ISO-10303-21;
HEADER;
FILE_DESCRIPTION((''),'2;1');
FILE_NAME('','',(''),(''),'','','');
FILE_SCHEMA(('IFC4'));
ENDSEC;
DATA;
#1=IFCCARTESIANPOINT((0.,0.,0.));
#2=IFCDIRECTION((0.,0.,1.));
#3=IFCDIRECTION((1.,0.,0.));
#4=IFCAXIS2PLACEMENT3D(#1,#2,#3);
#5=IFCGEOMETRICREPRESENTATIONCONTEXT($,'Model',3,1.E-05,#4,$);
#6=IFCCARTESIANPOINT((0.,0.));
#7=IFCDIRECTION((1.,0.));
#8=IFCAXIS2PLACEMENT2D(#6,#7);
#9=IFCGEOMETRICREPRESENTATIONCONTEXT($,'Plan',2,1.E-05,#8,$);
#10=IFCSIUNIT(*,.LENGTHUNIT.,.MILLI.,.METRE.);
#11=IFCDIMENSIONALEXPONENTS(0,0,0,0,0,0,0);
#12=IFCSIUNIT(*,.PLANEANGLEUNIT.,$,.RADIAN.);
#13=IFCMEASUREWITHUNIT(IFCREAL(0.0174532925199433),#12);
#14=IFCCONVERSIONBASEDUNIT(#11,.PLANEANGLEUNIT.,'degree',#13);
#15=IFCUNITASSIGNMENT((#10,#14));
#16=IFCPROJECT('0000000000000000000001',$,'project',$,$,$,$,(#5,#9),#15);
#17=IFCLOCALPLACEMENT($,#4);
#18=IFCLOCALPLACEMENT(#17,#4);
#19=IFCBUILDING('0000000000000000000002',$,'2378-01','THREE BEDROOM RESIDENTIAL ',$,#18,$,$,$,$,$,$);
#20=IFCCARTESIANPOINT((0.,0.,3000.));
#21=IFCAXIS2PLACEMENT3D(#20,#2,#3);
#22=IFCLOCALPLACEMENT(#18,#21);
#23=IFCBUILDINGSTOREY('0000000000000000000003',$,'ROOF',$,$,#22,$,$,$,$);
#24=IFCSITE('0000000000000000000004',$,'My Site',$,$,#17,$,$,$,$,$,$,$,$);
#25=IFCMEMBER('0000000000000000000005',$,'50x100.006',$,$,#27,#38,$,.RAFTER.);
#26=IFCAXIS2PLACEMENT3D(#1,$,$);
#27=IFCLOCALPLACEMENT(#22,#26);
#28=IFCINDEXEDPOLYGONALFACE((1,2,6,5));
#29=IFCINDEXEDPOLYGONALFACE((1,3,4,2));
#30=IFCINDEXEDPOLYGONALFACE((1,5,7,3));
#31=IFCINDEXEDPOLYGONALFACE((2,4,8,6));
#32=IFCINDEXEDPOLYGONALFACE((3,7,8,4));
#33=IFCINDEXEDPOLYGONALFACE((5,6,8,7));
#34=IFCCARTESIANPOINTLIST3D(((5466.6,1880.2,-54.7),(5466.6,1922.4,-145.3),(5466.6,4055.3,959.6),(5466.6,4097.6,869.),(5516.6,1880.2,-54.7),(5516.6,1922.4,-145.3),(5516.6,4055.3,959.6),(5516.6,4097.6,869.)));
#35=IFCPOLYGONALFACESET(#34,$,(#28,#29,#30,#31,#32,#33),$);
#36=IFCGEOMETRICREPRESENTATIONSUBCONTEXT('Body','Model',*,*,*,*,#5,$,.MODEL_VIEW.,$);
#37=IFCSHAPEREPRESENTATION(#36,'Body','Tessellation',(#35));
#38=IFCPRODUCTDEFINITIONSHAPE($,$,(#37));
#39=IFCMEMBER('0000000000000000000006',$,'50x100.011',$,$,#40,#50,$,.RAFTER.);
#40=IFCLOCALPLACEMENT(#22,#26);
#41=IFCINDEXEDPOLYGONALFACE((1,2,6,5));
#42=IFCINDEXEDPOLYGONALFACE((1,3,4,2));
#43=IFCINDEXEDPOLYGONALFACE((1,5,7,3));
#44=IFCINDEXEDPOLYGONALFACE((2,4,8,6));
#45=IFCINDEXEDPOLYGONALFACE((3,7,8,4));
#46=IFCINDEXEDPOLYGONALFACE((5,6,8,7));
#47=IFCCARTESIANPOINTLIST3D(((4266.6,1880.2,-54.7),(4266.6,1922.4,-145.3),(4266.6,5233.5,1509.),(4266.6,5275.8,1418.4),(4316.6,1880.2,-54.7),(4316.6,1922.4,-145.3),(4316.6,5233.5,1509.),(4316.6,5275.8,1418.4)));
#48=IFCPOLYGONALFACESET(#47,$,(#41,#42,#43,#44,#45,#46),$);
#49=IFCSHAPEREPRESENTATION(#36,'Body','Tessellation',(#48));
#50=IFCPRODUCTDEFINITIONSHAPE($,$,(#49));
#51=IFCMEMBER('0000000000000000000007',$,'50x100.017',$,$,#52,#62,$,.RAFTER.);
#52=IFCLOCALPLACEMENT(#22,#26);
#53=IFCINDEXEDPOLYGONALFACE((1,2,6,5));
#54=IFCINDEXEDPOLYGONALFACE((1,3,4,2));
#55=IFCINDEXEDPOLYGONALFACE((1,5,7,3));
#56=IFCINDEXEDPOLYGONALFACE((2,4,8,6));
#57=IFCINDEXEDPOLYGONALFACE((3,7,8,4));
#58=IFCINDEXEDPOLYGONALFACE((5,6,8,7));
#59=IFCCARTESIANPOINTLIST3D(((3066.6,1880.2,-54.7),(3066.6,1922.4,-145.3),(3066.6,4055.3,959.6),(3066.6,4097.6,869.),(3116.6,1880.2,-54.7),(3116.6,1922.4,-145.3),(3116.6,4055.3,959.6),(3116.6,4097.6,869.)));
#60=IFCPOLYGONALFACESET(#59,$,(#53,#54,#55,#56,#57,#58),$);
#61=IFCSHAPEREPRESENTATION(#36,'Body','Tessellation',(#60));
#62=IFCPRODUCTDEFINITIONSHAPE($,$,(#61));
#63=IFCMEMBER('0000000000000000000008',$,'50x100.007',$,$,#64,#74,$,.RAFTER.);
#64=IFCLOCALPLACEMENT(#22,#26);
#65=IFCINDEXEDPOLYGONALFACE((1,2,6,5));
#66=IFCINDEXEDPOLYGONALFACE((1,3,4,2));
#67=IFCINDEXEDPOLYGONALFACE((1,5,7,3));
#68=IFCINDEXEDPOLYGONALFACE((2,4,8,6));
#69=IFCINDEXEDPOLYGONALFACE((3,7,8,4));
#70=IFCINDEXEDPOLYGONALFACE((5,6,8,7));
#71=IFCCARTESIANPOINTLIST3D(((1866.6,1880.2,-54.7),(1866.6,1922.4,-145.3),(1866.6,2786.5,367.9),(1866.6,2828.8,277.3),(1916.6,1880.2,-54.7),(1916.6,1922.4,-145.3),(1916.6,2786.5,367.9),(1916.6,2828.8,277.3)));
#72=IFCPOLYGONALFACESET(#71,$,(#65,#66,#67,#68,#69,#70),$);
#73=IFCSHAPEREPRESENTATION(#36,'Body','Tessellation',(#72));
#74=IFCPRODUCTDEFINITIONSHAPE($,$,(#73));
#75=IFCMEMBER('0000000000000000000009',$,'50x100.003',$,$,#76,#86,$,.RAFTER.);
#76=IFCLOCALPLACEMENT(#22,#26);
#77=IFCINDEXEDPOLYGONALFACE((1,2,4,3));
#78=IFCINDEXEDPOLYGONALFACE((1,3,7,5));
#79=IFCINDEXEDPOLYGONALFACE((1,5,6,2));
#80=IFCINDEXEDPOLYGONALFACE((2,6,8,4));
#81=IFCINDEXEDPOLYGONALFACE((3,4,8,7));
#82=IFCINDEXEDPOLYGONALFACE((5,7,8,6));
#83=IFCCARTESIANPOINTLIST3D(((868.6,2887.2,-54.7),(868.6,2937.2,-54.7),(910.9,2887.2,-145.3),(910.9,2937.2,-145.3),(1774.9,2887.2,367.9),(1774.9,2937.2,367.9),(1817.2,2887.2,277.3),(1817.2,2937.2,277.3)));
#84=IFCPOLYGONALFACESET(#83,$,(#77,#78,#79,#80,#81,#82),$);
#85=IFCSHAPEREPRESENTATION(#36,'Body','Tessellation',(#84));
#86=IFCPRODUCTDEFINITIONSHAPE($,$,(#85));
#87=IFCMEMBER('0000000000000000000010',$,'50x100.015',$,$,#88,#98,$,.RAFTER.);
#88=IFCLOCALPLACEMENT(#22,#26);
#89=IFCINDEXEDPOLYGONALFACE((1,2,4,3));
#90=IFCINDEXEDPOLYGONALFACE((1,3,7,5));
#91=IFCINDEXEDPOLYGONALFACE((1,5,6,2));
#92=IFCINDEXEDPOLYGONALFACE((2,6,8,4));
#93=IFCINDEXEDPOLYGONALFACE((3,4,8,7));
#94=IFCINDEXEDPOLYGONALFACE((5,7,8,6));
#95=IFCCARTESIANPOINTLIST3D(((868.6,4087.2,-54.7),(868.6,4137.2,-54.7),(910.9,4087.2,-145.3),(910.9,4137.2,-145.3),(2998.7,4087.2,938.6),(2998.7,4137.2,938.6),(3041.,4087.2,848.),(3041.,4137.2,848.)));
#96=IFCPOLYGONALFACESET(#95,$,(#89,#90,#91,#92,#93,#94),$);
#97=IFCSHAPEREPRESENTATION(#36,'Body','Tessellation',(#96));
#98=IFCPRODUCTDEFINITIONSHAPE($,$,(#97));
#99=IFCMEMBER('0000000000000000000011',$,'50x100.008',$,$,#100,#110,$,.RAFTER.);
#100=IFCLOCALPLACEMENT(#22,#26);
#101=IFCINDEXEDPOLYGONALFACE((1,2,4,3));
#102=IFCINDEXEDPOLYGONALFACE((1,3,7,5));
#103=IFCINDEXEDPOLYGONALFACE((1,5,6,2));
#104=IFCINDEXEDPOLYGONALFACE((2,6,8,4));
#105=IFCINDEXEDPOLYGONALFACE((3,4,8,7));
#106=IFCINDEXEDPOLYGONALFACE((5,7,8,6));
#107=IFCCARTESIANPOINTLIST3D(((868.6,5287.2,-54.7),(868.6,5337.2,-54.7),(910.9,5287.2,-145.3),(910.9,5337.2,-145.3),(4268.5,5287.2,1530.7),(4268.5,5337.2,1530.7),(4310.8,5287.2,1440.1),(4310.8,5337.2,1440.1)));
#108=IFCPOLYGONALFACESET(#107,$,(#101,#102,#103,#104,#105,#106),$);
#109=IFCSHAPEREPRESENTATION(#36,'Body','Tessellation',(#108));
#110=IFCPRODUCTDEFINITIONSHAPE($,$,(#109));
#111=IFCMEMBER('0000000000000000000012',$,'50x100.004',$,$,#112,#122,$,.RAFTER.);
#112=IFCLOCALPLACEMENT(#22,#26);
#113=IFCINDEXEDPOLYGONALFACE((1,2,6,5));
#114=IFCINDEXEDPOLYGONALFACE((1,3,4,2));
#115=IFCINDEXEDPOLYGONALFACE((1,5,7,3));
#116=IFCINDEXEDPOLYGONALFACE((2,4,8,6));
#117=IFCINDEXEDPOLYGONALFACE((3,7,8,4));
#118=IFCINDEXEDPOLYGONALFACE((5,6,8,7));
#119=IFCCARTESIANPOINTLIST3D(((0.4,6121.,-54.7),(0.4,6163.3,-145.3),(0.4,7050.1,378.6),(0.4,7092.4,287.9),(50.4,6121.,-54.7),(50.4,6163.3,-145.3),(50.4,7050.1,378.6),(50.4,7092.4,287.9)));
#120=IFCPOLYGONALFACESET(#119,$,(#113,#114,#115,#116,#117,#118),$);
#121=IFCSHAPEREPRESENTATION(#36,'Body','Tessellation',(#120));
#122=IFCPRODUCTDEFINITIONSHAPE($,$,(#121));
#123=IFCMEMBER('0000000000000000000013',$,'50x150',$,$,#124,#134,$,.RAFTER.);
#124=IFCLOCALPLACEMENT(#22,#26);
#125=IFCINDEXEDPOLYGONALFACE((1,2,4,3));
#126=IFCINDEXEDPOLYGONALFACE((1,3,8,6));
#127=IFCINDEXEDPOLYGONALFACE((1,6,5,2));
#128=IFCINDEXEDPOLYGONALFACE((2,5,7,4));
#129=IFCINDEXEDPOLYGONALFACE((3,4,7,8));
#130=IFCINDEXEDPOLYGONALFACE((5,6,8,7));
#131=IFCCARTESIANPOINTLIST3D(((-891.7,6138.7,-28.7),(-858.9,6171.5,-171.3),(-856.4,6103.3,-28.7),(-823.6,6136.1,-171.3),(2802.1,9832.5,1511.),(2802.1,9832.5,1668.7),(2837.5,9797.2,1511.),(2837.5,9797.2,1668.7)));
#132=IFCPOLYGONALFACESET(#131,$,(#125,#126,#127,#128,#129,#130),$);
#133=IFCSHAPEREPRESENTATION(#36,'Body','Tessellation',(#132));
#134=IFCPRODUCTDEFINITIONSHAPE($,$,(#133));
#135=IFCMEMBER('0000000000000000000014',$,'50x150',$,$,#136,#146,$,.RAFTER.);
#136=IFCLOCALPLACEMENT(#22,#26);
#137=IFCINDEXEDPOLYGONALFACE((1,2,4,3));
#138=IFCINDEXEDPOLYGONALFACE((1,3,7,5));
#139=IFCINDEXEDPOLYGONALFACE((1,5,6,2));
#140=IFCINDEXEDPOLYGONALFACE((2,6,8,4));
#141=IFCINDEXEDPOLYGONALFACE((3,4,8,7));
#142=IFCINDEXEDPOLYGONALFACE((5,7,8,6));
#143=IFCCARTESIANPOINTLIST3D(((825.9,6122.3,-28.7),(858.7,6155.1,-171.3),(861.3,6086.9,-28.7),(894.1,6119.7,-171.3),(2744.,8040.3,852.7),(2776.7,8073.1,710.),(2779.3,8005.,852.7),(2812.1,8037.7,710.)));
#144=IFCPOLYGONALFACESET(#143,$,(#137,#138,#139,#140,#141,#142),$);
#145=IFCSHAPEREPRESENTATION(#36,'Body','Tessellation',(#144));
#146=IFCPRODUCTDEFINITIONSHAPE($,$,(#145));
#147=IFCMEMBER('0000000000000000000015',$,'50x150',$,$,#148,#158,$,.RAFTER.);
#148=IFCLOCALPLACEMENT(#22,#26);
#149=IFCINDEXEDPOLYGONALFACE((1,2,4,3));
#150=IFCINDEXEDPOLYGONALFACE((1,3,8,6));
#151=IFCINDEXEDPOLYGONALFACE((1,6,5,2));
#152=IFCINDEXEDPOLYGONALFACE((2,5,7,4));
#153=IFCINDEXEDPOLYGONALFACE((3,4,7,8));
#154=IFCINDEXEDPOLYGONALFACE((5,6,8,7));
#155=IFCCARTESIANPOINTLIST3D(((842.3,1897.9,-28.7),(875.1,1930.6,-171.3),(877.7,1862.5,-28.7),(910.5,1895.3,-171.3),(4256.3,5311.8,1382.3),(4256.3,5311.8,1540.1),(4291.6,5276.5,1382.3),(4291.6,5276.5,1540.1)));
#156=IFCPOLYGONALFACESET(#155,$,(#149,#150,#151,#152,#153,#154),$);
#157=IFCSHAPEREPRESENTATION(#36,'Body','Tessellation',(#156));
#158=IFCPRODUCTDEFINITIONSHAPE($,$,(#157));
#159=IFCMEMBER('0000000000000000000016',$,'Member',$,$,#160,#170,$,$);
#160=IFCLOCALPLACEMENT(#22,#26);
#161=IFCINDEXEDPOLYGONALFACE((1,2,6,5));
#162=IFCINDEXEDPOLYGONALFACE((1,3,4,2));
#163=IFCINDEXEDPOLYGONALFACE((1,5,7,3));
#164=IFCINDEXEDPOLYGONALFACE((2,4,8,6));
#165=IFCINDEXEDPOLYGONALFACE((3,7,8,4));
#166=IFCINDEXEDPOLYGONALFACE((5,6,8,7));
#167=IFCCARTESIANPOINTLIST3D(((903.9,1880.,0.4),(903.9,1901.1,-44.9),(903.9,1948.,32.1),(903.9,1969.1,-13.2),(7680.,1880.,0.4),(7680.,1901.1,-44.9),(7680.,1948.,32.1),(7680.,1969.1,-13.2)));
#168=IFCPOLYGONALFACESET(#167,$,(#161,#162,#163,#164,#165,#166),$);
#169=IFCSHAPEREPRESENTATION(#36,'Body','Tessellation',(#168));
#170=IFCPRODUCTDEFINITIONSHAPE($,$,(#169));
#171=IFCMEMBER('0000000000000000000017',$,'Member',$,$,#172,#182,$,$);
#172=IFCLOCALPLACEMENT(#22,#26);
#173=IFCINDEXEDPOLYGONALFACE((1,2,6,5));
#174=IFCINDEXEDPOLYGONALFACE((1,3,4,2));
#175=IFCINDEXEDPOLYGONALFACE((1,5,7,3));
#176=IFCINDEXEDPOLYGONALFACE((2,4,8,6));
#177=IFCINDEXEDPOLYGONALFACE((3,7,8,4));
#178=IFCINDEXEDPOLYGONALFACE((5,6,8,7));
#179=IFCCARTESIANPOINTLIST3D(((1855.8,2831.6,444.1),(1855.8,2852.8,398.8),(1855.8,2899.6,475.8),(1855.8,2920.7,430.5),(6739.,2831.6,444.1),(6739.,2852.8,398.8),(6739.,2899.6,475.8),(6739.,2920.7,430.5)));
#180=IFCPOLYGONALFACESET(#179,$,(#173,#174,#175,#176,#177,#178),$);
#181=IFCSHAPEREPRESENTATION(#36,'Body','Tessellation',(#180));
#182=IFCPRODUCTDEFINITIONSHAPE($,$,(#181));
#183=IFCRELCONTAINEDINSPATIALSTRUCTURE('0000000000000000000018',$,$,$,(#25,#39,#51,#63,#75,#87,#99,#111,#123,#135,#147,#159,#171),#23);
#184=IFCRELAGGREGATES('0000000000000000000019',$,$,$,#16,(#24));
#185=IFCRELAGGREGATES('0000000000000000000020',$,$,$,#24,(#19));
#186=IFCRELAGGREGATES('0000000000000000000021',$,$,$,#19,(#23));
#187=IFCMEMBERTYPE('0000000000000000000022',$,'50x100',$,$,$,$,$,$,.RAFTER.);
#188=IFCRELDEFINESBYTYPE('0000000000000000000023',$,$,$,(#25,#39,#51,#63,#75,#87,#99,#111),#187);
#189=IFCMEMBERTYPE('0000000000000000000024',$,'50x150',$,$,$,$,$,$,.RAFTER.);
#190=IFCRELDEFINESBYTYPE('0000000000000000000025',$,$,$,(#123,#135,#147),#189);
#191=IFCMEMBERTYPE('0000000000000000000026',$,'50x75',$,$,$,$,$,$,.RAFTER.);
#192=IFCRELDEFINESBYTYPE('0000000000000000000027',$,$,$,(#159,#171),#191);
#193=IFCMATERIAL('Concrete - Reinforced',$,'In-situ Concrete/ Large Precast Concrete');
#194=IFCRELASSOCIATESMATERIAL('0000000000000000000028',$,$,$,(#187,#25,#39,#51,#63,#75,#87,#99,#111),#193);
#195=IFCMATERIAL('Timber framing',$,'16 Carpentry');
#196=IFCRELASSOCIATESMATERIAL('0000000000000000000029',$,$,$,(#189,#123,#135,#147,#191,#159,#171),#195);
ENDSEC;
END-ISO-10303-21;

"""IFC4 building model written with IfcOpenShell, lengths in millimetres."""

from ifc_helpers import new_model, entity, si_unit, converted_unit, frame, origin_with_axes, origin_2d_with_axis, place, context, subcontext, project, spatial, rectangle, extrude, clip, halfspace, material, material_profile, profile_set, profile_usage, type_object, element, save


model = new_model("IFC4")

# Units and contexts
model_context = context("Model", 3, precision=1e-05, world=origin_with_axes())
plan_context = context("Plan", 2, precision=1e-05, world=origin_2d_with_axis())
body_context = subcontext(model_context, "Body", "Model", "MODEL_VIEW")
ifc_project = project(units=[si_unit("LENGTHUNIT", "METRE", prefix="MILLI"), converted_unit("PLANEANGLEUNIT", "degree", entity("IfcReal", 0.0174532925199433), si_unit("PLANEANGLEUNIT", "RADIAN"), dimensions=[0, 0, 0, 0, 0, 0, 0])], contexts=[model_context, plan_context])

# Site, building, storey
site_placement = place(None, origin_with_axes())
site = spatial("IfcSite", under=ifc_project, at=site_placement, Name="My Site")
building_placement = place(site_placement, origin_with_axes())
building = spatial("IfcBuilding", under=site, at=building_placement, Name="2378-01", Description="THREE BEDROOM RESIDENTIAL ")
storey_placement = place(building_placement, frame((0.0, 0.0, 3000.0), z_axis=(0.0, 0.0, 1.0), x_axis=(1.0, 0.0, 0.0)))
storey = spatial("IfcBuildingStorey", under=building, at=storey_placement, Name="ROOF")

# Members
ifc_material_1 = material(Name="Concrete - Reinforced", Category="In-situ Concrete/ Large Precast Concrete")
ifc_material_profile_1 = material_profile(ifc_material_1, rectangle(XDim=50.0, YDim=100.0), Name="Core Layer", Category="LoadBearing", Priority=1)
ifc_profile_set_1 = profile_set([ifc_material_profile_1], Name="wood")
ifc_profile_usage_1 = profile_usage(ifc_profile_set_1)
member_type_1 = type_object("IfcMemberType", Name="50x100", PredefinedType="RAFTER", material=ifc_profile_set_1)
member_1_placement = place(storey_placement, frame((5491.6, 1901.3, -100.0), z_axis=(0.0, 0.906308, 0.422618), x_axis=(-1.0, 0.0, 0.0)))
element("IfcMember", 1, at=member_1_placement, inside=storey, type_object=member_type_1, material=ifc_profile_usage_1, Name="50x100.006", PredefinedType="RAFTER", context=body_context, shape_type="SweptSolid", body=[
    extrude(rectangle(XDim=50.0, YDim=100.0), origin_with_axes(), (0.0, 0.0, 1.0), 2400.0),
])
ifc_profile_usage_2 = profile_usage(ifc_profile_set_1)
member_2_placement = place(storey_placement, frame((4291.6, 1901.3, -100.0), z_axis=(0.0, 0.906308, 0.422618), x_axis=(-1.0, 0.0, 0.0)))
element("IfcMember", 2, at=member_2_placement, inside=storey, type_object=member_type_1, material=ifc_profile_usage_2, Name="50x100.011", PredefinedType="RAFTER", context=body_context, shape_type="SweptSolid", body=[
    extrude(rectangle(XDim=50.0, YDim=100.0), origin_with_axes(), (0.0, 0.0, 1.0), 3700.0),
])
ifc_profile_usage_3 = profile_usage(ifc_profile_set_1)
member_3_placement = place(storey_placement, frame((3091.6, 1901.3, -100.0), z_axis=(0.0, 0.906308, 0.422618), x_axis=(-1.0, 0.0, 0.0)))
element("IfcMember", 3, at=member_3_placement, inside=storey, type_object=member_type_1, material=ifc_profile_usage_3, Name="50x100.017", PredefinedType="RAFTER", context=body_context, shape_type="SweptSolid", body=[
    extrude(rectangle(XDim=50.0, YDim=100.0), origin_with_axes(), (0.0, 0.0, 1.0), 2400.0),
])
ifc_profile_usage_4 = profile_usage(ifc_profile_set_1)
member_4_placement = place(storey_placement, frame((1891.6, 1901.3, -100.0), z_axis=(0.0, 0.906308, 0.422618), x_axis=(-1.0, 0.0, 0.0)))
element("IfcMember", 4, at=member_4_placement, inside=storey, type_object=member_type_1, material=ifc_profile_usage_4, Name="50x100.007", PredefinedType="RAFTER", context=body_context, shape_type="SweptSolid", body=[
    extrude(rectangle(XDim=50.0, YDim=100.0), origin_with_axes(), (0.0, 0.0, 1.0), 1000.0),
])
ifc_profile_usage_5 = profile_usage(ifc_profile_set_1)
member_5_placement = place(storey_placement, frame((889.7, 2912.2, -100.0), z_axis=(0.906308, 0.0, 0.422618), x_axis=(0.0, 1.0, 0.0)))
element("IfcMember", 5, at=member_5_placement, inside=storey, type_object=member_type_1, material=ifc_profile_usage_5, Name="50x100.003", PredefinedType="RAFTER", context=body_context, shape_type="SweptSolid", body=[
    extrude(rectangle(XDim=50.0, YDim=100.0), origin_with_axes(), (0.0, 0.0, 1.0), 1000.0),
])
ifc_profile_usage_6 = profile_usage(ifc_profile_set_1)
member_6_placement = place(storey_placement, frame((889.7, 4112.2, -100.0), z_axis=(0.906308, 0.0, 0.422618), x_axis=(0.0, 1.0, 0.0)))
element("IfcMember", 6, at=member_6_placement, inside=storey, type_object=member_type_1, material=ifc_profile_usage_6, Name="50x100.015", PredefinedType="RAFTER", context=body_context, shape_type="SweptSolid", body=[
    extrude(rectangle(XDim=50.0, YDim=100.0), origin_with_axes(), (0.0, 0.0, 1.0), 2350.3),
])
ifc_profile_usage_7 = profile_usage(ifc_profile_set_1)
member_7_placement = place(storey_placement, frame((889.7, 5312.2, -100.0), z_axis=(0.906308, 0.0, 0.422618), x_axis=(0.0, 1.0, 0.0)))
element("IfcMember", 7, at=member_7_placement, inside=storey, type_object=member_type_1, material=ifc_profile_usage_7, Name="50x100.008", PredefinedType="RAFTER", context=body_context, shape_type="SweptSolid", body=[
    extrude(rectangle(XDim=50.0, YDim=100.0), origin_with_axes(), (0.0, 0.0, 1.0), 3751.4),
])
ifc_profile_usage_8 = profile_usage(ifc_profile_set_1)
member_8_placement = place(storey_placement, frame((25.4, 6142.1, -100.0), z_axis=(0.0, 0.906308, 0.422618), x_axis=(-1.0, 0.0, 0.0)))
element("IfcMember", 8, at=member_8_placement, inside=storey, type_object=member_type_1, material=ifc_profile_usage_8, Name="50x100.004", PredefinedType="RAFTER", context=body_context, shape_type="SweptSolid", body=[
    extrude(rectangle(XDim=50.0, YDim=100.0), origin_with_axes(), (0.0, 0.0, 1.0), 1025.2),
])
ifc_material_2 = material(Name="Timber framing", Category="16 Carpentry")
ifc_material_profile_2 = material_profile(ifc_material_2, rectangle(XDim=50.0, YDim=150.0), Name="Lumber", Category="LoadBearing", Priority=1)
ifc_profile_set_2 = profile_set([ifc_material_profile_2], Name="wood")
ifc_profile_usage_9 = profile_usage(ifc_profile_set_2)
member_type_2 = type_object("IfcMemberType", Name="50x150", PredefinedType="RAFTER", material=ifc_profile_set_2)
member_9_placement = place(storey_placement, frame((-857.6, 6137.4, -100.0), z_axis=(0.672499, 0.672498, 0.309017), x_axis=(-0.707106, 0.707107, 0.0)))
element("IfcMember", 9, at=member_9_placement, inside=storey, type_object=member_type_2, material=ifc_profile_usage_9, Name="50x150", PredefinedType="RAFTER", context=body_context, shape_type="Clipping", body=[
    clip(extrude(rectangle(XDim=50.0, YDim=150.0), origin_with_axes(), (0.0, 0.0, 1.0), 5618.3), halfspace(frame((254.6, 177.9, 5526.2), z_axis=(0.0, -0.309017, 0.951057), x_axis=(-1.0, -0.000002, 0.0)), False)),
])
ifc_profile_usage_10 = profile_usage(ifc_profile_set_2)
member_10_placement = place(storey_placement, frame((860.0, 6121.0, -100.0), z_axis=(0.672499, 0.672499, 0.309017), x_axis=(-0.707107, 0.707107, 0.0)))
element("IfcMember", 10, at=member_10_placement, inside=storey, type_object=member_type_2, material=ifc_profile_usage_10, Name="50x150", PredefinedType="RAFTER", context=body_context, shape_type="SweptSolid", body=[
    extrude(rectangle(XDim=50.0, YDim=150.0), origin_with_axes(), (0.0, 0.0, 1.0), 2852.1),
])
ifc_profile_usage_11 = profile_usage(ifc_profile_set_2)
member_11_placement = place(storey_placement, frame((876.4, 1896.6, -100.0), z_axis=(0.672499, 0.672498, 0.309017), x_axis=(-0.707106, 0.707107, 0.0)))
element("IfcMember", 11, at=member_11_placement, inside=storey, type_object=member_type_2, material=ifc_profile_usage_11, Name="50x150", PredefinedType="RAFTER", context=body_context, shape_type="Clipping", body=[
    clip(extrude(rectangle(XDim=50.0, YDim=150.0), origin_with_axes(), (0.0, 0.0, 1.0), 5202.2), halfspace(frame((-4829.9, -1484.8, 4569.7), z_axis=(0.0, -0.309017, 0.951056), x_axis=(-1.0, -0.000001, 0.0)), False)),
])
ifc_material_profile_3 = material_profile(ifc_material_2, rectangle(XDim=50.0, YDim=75.0), Name="Lumber2", Category="Substrate", Priority=2)
ifc_profile_set_3 = profile_set([ifc_material_profile_3])
ifc_profile_usage_12 = profile_usage(ifc_profile_set_3, cardinal=5)
member_type_3 = type_object("IfcMemberType", Name="50x75", PredefinedType="RAFTER", material=ifc_profile_set_3)
member_12_placement = place(storey_placement, frame((903.9, 1924.6, -6.4), z_axis=(1.0, 0.0, 0.0), x_axis=(0.0, 0.422618, -0.906308)))
element("IfcMember", 12, at=member_12_placement, inside=storey, type_object=member_type_3, material=ifc_profile_usage_12, Name="Member", context=body_context, shape_type="SweptSolid", body=[
    extrude(rectangle(XDim=50.0, YDim=75.0), origin_with_axes(), (0.0, 0.0, 1.0), 6776.1),
])
ifc_profile_usage_13 = profile_usage(ifc_profile_set_3, cardinal=5)
member_13_placement = place(storey_placement, frame((1855.8, 2876.2, 437.3), z_axis=(1.0, 0.0, 0.0), x_axis=(0.0, 0.422618, -0.906308)))
element("IfcMember", 13, at=member_13_placement, inside=storey, type_object=member_type_3, material=ifc_profile_usage_13, Name="Member", context=body_context, shape_type="SweptSolid", body=[
    extrude(rectangle(XDim=50.0, YDim=75.0), origin_with_axes(), (0.0, 0.0, 1.0), 4883.3),
])

save(model, "model.ifc")
